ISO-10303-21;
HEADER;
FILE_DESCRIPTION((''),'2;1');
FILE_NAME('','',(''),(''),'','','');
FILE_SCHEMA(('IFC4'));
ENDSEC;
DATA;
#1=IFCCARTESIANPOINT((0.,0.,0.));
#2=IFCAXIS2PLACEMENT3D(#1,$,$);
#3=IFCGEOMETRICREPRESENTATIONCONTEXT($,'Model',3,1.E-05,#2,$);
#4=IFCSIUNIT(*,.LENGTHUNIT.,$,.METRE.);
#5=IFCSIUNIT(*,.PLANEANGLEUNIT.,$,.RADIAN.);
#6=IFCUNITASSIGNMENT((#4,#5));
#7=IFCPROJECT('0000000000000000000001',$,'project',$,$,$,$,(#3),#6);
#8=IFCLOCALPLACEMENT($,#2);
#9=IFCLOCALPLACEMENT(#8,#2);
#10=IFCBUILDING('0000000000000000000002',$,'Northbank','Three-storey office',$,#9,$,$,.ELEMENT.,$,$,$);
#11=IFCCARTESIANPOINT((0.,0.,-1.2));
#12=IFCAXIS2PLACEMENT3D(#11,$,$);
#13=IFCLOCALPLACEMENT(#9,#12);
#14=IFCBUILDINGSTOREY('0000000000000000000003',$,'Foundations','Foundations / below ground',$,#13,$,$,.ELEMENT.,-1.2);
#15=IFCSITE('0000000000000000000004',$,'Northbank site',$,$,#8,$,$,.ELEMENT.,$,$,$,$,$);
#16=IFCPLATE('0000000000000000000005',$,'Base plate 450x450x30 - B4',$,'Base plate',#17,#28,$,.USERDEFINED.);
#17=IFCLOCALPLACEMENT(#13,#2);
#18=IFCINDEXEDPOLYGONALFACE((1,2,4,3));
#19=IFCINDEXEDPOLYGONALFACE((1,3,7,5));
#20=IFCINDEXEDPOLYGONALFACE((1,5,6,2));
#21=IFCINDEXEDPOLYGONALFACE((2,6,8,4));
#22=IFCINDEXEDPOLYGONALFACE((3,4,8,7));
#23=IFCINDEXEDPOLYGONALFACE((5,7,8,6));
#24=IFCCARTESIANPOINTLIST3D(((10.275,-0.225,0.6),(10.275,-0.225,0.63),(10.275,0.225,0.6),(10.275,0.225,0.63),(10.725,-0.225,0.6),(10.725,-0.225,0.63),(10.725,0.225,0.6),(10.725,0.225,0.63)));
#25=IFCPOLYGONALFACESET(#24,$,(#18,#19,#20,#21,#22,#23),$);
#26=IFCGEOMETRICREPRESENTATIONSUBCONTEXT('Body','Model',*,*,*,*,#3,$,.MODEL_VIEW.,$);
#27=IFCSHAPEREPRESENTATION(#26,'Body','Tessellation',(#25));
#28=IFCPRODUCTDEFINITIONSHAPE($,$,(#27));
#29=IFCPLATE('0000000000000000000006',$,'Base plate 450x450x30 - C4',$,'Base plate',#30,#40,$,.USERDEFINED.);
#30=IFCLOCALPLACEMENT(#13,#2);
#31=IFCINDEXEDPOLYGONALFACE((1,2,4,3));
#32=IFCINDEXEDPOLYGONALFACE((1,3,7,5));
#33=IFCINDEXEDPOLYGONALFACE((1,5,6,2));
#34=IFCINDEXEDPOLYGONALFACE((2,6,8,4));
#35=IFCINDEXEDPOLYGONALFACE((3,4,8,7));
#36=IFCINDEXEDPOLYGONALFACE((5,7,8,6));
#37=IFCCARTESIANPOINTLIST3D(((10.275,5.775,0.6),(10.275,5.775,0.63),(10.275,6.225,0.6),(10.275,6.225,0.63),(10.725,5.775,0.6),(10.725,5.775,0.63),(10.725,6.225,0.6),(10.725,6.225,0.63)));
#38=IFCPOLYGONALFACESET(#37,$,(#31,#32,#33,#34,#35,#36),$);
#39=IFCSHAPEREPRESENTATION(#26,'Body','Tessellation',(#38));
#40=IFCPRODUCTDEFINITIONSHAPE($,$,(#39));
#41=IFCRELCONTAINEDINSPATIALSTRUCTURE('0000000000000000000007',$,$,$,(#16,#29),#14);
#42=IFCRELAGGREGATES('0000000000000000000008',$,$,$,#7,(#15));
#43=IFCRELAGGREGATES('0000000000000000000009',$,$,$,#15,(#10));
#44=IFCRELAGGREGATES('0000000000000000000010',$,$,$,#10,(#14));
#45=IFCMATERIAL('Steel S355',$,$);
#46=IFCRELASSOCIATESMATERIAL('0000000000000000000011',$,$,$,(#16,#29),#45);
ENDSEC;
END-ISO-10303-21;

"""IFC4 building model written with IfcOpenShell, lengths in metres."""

from ifc_helpers import new_model, si_unit, frame, origin, place, context, subcontext, project, spatial, rectangle, extrude, material, element, save


model = new_model("IFC4")

# Units and contexts
model_context = context("Model", 3, precision=1e-05, world=origin())
body_context = subcontext(model_context, "Body", "Model", "MODEL_VIEW")
ifc_project = project(units=[si_unit("LENGTHUNIT", "METRE"), si_unit("PLANEANGLEUNIT", "RADIAN")], contexts=[model_context])

# Site, building, storey
site_placement = place(None, origin())
site = spatial("IfcSite", under=ifc_project, at=site_placement, Name="Northbank site", CompositionType="ELEMENT")
building_placement = place(site_placement, origin())
building = spatial("IfcBuilding", under=site, at=building_placement, Name="Northbank", Description="Three-storey office", CompositionType="ELEMENT")
storey_placement = place(building_placement, frame((0.0, 0.0, -1.2)))
storey = spatial("IfcBuildingStorey", under=building, at=storey_placement, Name="Foundations", Description="Foundations / below ground", CompositionType="ELEMENT", Elevation=-1.2)

# Plates
ifc_material_1 = material(Name="Steel S355")
plate_1_placement = place(storey_placement, frame((0.0, 0.0, 1.2)))
element("IfcPlate", 1, at=plate_1_placement, inside=storey, material=ifc_material_1, Name="Base plate 450x450x30 - B4", ObjectType="Base plate", PredefinedType="USERDEFINED", context=body_context, shape_type="SweptSolid", body=[
    extrude(rectangle(XDim=0.45, YDim=0.45), frame((10.5, 0.0, -0.6)), (0.0, 0.0, 1.0), 0.03),
])
plate_2_placement = place(storey_placement, frame((0.0, 0.0, 1.2)))
element("IfcPlate", 2, at=plate_2_placement, inside=storey, material=ifc_material_1, Name="Base plate 450x450x30 - C4", ObjectType="Base plate", PredefinedType="USERDEFINED", context=body_context, shape_type="SweptSolid", body=[
    extrude(rectangle(XDim=0.45, YDim=0.45), frame((10.5, 6.0, -0.6)), (0.0, 0.0, 1.0), 0.03),
])

save(model, "model.ifc")
